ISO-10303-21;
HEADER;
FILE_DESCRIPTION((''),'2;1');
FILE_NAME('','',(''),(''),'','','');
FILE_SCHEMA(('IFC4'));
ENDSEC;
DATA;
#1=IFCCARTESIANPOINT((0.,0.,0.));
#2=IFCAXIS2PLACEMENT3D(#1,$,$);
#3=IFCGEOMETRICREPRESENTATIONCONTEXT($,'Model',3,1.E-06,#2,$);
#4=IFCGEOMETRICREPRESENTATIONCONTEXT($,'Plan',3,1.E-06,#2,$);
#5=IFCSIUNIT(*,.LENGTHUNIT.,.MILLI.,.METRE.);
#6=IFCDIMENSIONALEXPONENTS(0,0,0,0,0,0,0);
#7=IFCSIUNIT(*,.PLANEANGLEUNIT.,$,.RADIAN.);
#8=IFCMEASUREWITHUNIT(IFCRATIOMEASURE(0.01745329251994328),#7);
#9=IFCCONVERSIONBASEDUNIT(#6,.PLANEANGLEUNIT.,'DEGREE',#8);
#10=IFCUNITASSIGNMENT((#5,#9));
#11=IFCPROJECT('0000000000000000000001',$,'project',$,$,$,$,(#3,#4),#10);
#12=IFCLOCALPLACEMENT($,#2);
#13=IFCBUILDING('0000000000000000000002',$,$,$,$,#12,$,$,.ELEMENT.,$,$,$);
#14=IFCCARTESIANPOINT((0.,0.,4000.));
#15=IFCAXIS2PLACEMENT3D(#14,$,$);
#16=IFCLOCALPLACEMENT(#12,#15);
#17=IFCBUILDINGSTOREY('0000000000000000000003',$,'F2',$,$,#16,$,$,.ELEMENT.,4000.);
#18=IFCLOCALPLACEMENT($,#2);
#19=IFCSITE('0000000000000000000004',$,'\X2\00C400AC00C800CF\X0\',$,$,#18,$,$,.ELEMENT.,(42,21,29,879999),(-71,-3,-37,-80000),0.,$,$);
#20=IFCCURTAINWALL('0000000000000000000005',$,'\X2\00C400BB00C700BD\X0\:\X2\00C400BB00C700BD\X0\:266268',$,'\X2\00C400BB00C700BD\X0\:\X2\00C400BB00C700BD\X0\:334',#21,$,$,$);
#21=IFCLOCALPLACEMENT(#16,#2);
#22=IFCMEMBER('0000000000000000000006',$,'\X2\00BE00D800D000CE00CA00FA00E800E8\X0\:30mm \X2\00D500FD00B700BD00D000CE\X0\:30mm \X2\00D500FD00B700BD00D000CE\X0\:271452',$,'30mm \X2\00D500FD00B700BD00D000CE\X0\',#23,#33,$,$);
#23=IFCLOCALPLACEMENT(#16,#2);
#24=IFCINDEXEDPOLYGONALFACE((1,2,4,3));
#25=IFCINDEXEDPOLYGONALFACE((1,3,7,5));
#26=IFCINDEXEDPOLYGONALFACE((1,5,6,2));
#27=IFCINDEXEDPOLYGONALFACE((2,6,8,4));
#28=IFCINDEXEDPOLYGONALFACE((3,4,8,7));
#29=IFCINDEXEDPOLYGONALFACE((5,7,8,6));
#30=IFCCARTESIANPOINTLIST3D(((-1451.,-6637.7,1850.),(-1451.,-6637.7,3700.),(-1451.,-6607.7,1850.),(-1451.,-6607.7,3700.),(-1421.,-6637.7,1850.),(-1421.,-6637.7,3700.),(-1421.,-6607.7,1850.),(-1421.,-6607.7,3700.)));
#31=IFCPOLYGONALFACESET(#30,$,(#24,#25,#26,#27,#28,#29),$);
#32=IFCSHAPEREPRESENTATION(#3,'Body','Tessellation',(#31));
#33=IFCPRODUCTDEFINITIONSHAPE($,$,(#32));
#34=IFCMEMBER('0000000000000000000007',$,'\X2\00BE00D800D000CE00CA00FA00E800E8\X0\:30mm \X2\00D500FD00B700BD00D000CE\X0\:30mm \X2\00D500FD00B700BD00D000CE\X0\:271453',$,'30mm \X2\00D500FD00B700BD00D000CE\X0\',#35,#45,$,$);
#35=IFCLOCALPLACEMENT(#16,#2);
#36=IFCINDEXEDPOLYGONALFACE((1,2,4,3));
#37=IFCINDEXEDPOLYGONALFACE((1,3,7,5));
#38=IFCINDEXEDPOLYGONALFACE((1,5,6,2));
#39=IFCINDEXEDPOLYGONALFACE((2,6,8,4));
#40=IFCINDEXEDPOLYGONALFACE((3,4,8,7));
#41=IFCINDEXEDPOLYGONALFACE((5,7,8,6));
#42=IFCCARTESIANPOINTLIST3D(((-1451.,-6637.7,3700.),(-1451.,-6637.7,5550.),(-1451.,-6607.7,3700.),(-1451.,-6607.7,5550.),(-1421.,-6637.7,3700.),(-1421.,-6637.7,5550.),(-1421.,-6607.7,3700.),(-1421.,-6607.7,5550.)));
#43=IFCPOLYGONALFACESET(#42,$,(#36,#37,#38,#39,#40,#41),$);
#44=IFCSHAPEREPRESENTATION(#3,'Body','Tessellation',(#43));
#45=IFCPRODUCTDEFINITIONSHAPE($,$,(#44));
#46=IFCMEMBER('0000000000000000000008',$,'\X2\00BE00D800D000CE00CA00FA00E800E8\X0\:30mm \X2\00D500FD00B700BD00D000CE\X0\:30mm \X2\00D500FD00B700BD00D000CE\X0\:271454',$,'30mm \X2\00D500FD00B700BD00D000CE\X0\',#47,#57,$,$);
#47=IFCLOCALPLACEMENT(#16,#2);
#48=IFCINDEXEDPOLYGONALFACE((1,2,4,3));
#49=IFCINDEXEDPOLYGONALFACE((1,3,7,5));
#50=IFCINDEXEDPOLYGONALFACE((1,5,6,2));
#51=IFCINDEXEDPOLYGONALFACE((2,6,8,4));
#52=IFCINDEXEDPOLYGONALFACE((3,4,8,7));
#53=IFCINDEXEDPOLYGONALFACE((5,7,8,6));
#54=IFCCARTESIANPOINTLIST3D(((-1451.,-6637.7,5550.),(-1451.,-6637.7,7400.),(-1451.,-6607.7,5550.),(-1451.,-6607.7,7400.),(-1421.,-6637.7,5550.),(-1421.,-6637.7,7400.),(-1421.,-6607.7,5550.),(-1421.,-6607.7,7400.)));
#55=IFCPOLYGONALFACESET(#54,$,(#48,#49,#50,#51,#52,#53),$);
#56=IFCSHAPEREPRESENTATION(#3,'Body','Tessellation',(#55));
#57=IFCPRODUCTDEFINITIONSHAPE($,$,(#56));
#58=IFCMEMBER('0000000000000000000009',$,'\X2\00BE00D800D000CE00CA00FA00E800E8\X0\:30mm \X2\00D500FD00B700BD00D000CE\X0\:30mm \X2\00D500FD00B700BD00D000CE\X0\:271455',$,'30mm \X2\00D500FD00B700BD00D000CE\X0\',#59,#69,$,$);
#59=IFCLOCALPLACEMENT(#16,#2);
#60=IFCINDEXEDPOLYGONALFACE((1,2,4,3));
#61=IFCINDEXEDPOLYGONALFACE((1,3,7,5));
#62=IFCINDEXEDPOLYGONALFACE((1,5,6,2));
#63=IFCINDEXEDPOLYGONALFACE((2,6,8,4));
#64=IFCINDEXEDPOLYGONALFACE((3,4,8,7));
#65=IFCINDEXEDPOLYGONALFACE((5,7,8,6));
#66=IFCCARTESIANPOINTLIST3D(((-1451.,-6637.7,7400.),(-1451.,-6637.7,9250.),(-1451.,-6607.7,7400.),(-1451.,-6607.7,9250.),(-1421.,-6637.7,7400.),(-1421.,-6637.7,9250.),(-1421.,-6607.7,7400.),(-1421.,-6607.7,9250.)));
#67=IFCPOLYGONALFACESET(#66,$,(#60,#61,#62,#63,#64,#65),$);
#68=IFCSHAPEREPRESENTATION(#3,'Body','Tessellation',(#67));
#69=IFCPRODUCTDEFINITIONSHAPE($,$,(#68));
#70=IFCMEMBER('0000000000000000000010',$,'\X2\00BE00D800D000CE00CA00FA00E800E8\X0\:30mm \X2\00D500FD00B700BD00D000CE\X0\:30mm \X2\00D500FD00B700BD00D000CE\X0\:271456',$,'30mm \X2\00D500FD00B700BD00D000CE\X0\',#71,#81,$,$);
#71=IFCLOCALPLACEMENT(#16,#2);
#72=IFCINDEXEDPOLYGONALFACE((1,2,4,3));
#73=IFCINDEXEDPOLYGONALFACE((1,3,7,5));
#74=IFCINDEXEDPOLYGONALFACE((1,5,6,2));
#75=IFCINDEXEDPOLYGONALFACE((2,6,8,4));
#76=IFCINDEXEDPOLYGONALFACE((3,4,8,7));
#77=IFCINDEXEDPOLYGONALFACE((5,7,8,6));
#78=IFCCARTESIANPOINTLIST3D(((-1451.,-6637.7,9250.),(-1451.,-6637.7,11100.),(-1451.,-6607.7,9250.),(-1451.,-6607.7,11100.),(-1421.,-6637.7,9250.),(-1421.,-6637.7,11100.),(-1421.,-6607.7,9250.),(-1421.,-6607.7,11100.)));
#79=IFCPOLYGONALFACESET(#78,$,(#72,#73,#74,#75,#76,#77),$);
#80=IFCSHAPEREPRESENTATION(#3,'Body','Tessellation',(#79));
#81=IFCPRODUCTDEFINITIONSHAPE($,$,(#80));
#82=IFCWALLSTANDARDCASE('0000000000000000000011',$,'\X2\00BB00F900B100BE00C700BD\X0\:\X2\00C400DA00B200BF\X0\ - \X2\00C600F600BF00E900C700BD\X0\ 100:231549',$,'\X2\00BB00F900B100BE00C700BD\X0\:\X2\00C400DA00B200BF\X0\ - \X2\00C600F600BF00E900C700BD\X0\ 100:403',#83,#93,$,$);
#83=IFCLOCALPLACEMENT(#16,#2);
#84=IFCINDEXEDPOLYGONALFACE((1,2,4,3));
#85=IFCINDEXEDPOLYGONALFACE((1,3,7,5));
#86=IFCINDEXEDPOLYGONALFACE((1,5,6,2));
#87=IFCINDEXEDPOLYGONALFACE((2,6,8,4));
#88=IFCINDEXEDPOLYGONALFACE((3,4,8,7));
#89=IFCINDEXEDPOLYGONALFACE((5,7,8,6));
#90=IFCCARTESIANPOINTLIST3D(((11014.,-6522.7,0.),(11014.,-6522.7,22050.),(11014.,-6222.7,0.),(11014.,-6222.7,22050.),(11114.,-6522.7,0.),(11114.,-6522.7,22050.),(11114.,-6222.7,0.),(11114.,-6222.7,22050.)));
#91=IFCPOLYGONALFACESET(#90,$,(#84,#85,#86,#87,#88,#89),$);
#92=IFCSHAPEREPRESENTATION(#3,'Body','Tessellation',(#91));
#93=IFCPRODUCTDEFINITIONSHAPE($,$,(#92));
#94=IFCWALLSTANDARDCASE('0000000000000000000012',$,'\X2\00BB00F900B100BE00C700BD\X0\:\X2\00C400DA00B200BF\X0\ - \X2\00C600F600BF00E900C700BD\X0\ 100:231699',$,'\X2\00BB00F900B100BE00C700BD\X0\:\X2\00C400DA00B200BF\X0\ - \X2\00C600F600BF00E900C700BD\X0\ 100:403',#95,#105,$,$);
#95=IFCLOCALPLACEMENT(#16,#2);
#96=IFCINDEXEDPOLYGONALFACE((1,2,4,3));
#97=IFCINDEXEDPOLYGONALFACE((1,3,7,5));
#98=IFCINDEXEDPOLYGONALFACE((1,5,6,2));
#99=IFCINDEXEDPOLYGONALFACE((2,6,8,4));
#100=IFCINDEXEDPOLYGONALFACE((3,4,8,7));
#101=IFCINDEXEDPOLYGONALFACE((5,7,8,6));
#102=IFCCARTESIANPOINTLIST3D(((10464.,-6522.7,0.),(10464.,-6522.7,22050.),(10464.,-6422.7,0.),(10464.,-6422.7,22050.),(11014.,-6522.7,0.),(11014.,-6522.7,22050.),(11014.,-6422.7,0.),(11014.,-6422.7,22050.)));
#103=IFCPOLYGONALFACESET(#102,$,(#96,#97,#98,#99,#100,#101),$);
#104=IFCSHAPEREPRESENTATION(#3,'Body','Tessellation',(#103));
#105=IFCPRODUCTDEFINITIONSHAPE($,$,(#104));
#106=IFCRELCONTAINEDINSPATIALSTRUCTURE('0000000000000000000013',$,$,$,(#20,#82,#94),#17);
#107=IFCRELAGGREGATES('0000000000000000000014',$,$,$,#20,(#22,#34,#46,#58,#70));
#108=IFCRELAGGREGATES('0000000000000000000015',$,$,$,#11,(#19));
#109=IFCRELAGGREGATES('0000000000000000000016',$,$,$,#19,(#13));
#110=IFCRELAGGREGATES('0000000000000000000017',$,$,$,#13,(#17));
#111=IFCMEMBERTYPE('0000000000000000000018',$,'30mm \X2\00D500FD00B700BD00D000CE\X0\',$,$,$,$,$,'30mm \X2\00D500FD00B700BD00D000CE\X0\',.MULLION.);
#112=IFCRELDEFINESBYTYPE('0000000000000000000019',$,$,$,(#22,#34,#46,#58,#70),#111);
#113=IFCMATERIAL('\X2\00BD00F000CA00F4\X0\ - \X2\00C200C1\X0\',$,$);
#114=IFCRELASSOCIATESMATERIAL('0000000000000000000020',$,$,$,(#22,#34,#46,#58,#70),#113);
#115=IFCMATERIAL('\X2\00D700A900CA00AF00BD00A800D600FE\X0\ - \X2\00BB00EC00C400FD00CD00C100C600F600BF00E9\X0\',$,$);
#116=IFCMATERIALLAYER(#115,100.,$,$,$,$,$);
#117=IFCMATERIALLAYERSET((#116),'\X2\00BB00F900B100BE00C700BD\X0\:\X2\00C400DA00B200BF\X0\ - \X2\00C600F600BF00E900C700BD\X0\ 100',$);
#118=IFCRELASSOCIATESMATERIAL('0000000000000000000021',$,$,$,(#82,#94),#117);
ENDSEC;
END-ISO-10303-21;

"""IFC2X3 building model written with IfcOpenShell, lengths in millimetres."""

from ifc_helpers import new_model, entity, si_unit, converted_unit, frame, frame_2d, origin, origin_2d_with_axis, place, context, project, spatial, polyline, rectangle, extrude, clip, bounded_halfspace, source, transform, mapped, material, layer, layer_set, layer_usage, type_object, type_shapes, element, aggregate, save


model = new_model("IFC2X3")

# Units and contexts
model_context = context("Model", 3, precision=1e-06, world=origin())
plan_context = context("Plan", 3, precision=1e-06, world=origin())
ifc_project = project(units=[si_unit("LENGTHUNIT", "METRE", prefix="MILLI"), converted_unit("PLANEANGLEUNIT", "DEGREE", entity("IfcRatioMeasure", 0.01745329251994328), si_unit("PLANEANGLEUNIT", "RADIAN"), dimensions=[0, 0, 0, 0, 0, 0, 0])], contexts=[model_context, plan_context])

# Site, building, storey
site_placement = place(None, origin())
site = spatial("IfcSite", under=ifc_project, at=site_placement, Name="Ä¬ÈÏ", CompositionType="ELEMENT", RefLatitude=(42, 21, 29, 879999), RefLongitude=(-71, -3, -37, -80000), RefElevation=0.0)
building_placement = place(None, origin())
building = spatial("IfcBuilding", under=site, at=building_placement, CompositionType="ELEMENT")
storey_placement = place(building_placement, frame((0.0, 0.0, 4000.0)))
storey = spatial("IfcBuildingStorey", under=building, at=storey_placement, Name="F2", CompositionType="ELEMENT", Elevation=4000.0)

# Curtain wall, members
curtain_wall_placement = place(storey_placement, origin())
curtain_wall = element("IfcCurtainWall", 1, at=curtain_wall_placement, inside=storey, Name="Ä»Ç½:Ä»Ç½:266268", ObjectType="Ä»Ç½:Ä»Ç½:334")
ifc_material_1 = material(Name="½ðÊô - ÂÁ")
placement_1 = place(building_placement, frame((0.0, 0.0, 11400.0)))
placement_2 = place(building_placement, frame((0.0, 0.0, 7700.0)))
member_type_1 = type_object("IfcMemberType", Name="30mm Õý·½ÐÎ", ElementType="30mm Õý·½ÐÎ", PredefinedType="MULLION")
shared_shape_1 = source(origin(), model_context, "Body", "SweptSolid", [
    extrude(rectangle(XDim=30.0, YDim=30.0, at=origin_2d_with_axis()), frame((0.0, 0.0, -1850.0), z_axis=(0.0, 0.0, 1.0), x_axis=(-1.0, 0.0, 0.0)), (0.0, 0.0, 1.0), 1850.0),
])
type_shapes(member_type_1, [shared_shape_1])
member_1_placement = place(storey_placement, frame((-1436.0, -6622.7, 1850.0), z_axis=(0.0, 0.0, -1.0), x_axis=(1.0, 0.0, 0.0)))
member_1 = element("IfcMember", 2, at=member_1_placement, type_object=member_type_1, material=ifc_material_1, Name="¾ØÐÎÊúèè:30mm Õý·½ÐÎ:30mm Õý·½ÐÎ:271452", ObjectType="30mm Õý·½ÐÎ", context=model_context, shape_type="MappedRepresentation", body=[
    mapped(shared_shape_1, transform((0.0, 0.0, 0.0), scale=1.0)),
])
member_2_placement = place(placement_2, frame((-1436.0, -6622.7, 0.0), z_axis=(0.0, 0.0, -1.0), x_axis=(1.0, 0.0, 0.0)))
member_2 = element("IfcMember", 3, at=member_2_placement, type_object=member_type_1, material=ifc_material_1, Name="¾ØÐÎÊúèè:30mm Õý·½ÐÎ:30mm Õý·½ÐÎ:271453", ObjectType="30mm Õý·½ÐÎ", context=model_context, shape_type="MappedRepresentation", body=[
    mapped(shared_shape_1, transform((0.0, 0.0, 0.0), scale=1.0)),
])
member_3_placement = place(placement_2, frame((-1436.0, -6622.7, 1850.0), z_axis=(0.0, 0.0, -1.0), x_axis=(1.0, 0.0, 0.0)))
member_3 = element("IfcMember", 4, at=member_3_placement, type_object=member_type_1, material=ifc_material_1, Name="¾ØÐÎÊúèè:30mm Õý·½ÐÎ:30mm Õý·½ÐÎ:271454", ObjectType="30mm Õý·½ÐÎ", context=model_context, shape_type="MappedRepresentation", body=[
    mapped(shared_shape_1, transform((0.0, 0.0, 0.0), scale=1.0)),
])
member_4_placement = place(placement_1, frame((-1436.0, -6622.7, 0.0), z_axis=(0.0, 0.0, -1.0), x_axis=(1.0, 0.0, 0.0)))
member_4 = element("IfcMember", 5, at=member_4_placement, type_object=member_type_1, material=ifc_material_1, Name="¾ØÐÎÊúèè:30mm Õý·½ÐÎ:30mm Õý·½ÐÎ:271455", ObjectType="30mm Õý·½ÐÎ", context=model_context, shape_type="MappedRepresentation", body=[
    mapped(shared_shape_1, transform((0.0, 0.0, 0.0), scale=1.0)),
])
member_5_placement = place(placement_1, frame((-1436.0, -6622.7, 1850.0), z_axis=(0.0, 0.0, -1.0), x_axis=(1.0, 0.0, 0.0)))
member_5 = element("IfcMember", 6, at=member_5_placement, type_object=member_type_1, material=ifc_material_1, Name="¾ØÐÎÊúèè:30mm Õý·½ÐÎ:30mm Õý·½ÐÎ:271456", ObjectType="30mm Õý·½ÐÎ", context=model_context, shape_type="MappedRepresentation", body=[
    mapped(shared_shape_1, transform((0.0, 0.0, 0.0), scale=1.0)),
])

aggregate(curtain_wall, [member_1, member_2, member_3, member_4, member_5])

# Walls
ifc_material_2 = material(Name="×©Ê¯½¨Öþ - »ìÄýÍÁÆö¿é")
ifc_layer = layer(ifc_material_2, 100.0)
ifc_layer_set = layer_set([ifc_layer], Name="»ù±¾Ç½:ÄÚ²¿ - Æö¿éÇ½ 100")
ifc_layer_usage_1 = layer_usage(ifc_layer_set, "AXIS2", "NEGATIVE", 50.0)
wall_1_placement = place(storey_placement, frame((11064.0, -6222.7, 0.0), z_axis=(0.0, 0.0, 1.0), x_axis=(0.0, -1.0, 0.0)))
element("IfcWallStandardCase", 7, at=wall_1_placement, inside=storey, material=ifc_layer_usage_1, Name="»ù±¾Ç½:ÄÚ²¿ - Æö¿éÇ½ 100:231549", ObjectType="»ù±¾Ç½:ÄÚ²¿ - Æö¿éÇ½ 100:403", context=model_context, shape_type="Clipping", body=[
    clip(extrude(rectangle(XDim=300.0, YDim=100.0, at=frame_2d((150.0, 0.0), x_axis=(-1.0, 0.0))), origin(), (0.0, 0.0, 1.0), 22050.0), bounded_halfspace(frame((0.0, -50.0, 22050.0), z_axis=(0.0, 0.0, -1.0), x_axis=(0.0, 1.0, 0.0)), True, frame((0.0, -50.0, 22050.0)), polyline([(0.0, 0.0), (200.0, 0.0), (300.0, 0.0), (300.0, 100.0), (0.0, 100.0), (0.0, 0.0)]))),
])
ifc_layer_usage_2 = layer_usage(ifc_layer_set, "AXIS2", "NEGATIVE", 50.0)
wall_2_placement = place(storey_placement, frame((11014.0, -6472.7, 0.0), z_axis=(0.0, 0.0, 1.0), x_axis=(-1.0, 0.0, 0.0)))
element("IfcWallStandardCase", 8, at=wall_2_placement, inside=storey, material=ifc_layer_usage_2, Name="»ù±¾Ç½:ÄÚ²¿ - Æö¿éÇ½ 100:231699", ObjectType="»ù±¾Ç½:ÄÚ²¿ - Æö¿éÇ½ 100:403", context=model_context, shape_type="Clipping", body=[
    clip(extrude(rectangle(XDim=550.0, YDim=100.0, at=frame_2d((275.0, 0.0), x_axis=(-1.0, 0.0))), origin(), (0.0, 0.0, 1.0), 22050.0), bounded_halfspace(frame((0.0, -50.0, 22050.0), z_axis=(0.0, 0.0, -1.0), x_axis=(-1.0, 0.0, 0.0)), True, frame((0.0, -50.0, 22050.0)), polyline([(0.0, 0.0), (550.0, 0.0), (550.0, 100.0), (0.0, 100.0), (0.0, 0.0)]))),
])

save(model, "model.ifc")
